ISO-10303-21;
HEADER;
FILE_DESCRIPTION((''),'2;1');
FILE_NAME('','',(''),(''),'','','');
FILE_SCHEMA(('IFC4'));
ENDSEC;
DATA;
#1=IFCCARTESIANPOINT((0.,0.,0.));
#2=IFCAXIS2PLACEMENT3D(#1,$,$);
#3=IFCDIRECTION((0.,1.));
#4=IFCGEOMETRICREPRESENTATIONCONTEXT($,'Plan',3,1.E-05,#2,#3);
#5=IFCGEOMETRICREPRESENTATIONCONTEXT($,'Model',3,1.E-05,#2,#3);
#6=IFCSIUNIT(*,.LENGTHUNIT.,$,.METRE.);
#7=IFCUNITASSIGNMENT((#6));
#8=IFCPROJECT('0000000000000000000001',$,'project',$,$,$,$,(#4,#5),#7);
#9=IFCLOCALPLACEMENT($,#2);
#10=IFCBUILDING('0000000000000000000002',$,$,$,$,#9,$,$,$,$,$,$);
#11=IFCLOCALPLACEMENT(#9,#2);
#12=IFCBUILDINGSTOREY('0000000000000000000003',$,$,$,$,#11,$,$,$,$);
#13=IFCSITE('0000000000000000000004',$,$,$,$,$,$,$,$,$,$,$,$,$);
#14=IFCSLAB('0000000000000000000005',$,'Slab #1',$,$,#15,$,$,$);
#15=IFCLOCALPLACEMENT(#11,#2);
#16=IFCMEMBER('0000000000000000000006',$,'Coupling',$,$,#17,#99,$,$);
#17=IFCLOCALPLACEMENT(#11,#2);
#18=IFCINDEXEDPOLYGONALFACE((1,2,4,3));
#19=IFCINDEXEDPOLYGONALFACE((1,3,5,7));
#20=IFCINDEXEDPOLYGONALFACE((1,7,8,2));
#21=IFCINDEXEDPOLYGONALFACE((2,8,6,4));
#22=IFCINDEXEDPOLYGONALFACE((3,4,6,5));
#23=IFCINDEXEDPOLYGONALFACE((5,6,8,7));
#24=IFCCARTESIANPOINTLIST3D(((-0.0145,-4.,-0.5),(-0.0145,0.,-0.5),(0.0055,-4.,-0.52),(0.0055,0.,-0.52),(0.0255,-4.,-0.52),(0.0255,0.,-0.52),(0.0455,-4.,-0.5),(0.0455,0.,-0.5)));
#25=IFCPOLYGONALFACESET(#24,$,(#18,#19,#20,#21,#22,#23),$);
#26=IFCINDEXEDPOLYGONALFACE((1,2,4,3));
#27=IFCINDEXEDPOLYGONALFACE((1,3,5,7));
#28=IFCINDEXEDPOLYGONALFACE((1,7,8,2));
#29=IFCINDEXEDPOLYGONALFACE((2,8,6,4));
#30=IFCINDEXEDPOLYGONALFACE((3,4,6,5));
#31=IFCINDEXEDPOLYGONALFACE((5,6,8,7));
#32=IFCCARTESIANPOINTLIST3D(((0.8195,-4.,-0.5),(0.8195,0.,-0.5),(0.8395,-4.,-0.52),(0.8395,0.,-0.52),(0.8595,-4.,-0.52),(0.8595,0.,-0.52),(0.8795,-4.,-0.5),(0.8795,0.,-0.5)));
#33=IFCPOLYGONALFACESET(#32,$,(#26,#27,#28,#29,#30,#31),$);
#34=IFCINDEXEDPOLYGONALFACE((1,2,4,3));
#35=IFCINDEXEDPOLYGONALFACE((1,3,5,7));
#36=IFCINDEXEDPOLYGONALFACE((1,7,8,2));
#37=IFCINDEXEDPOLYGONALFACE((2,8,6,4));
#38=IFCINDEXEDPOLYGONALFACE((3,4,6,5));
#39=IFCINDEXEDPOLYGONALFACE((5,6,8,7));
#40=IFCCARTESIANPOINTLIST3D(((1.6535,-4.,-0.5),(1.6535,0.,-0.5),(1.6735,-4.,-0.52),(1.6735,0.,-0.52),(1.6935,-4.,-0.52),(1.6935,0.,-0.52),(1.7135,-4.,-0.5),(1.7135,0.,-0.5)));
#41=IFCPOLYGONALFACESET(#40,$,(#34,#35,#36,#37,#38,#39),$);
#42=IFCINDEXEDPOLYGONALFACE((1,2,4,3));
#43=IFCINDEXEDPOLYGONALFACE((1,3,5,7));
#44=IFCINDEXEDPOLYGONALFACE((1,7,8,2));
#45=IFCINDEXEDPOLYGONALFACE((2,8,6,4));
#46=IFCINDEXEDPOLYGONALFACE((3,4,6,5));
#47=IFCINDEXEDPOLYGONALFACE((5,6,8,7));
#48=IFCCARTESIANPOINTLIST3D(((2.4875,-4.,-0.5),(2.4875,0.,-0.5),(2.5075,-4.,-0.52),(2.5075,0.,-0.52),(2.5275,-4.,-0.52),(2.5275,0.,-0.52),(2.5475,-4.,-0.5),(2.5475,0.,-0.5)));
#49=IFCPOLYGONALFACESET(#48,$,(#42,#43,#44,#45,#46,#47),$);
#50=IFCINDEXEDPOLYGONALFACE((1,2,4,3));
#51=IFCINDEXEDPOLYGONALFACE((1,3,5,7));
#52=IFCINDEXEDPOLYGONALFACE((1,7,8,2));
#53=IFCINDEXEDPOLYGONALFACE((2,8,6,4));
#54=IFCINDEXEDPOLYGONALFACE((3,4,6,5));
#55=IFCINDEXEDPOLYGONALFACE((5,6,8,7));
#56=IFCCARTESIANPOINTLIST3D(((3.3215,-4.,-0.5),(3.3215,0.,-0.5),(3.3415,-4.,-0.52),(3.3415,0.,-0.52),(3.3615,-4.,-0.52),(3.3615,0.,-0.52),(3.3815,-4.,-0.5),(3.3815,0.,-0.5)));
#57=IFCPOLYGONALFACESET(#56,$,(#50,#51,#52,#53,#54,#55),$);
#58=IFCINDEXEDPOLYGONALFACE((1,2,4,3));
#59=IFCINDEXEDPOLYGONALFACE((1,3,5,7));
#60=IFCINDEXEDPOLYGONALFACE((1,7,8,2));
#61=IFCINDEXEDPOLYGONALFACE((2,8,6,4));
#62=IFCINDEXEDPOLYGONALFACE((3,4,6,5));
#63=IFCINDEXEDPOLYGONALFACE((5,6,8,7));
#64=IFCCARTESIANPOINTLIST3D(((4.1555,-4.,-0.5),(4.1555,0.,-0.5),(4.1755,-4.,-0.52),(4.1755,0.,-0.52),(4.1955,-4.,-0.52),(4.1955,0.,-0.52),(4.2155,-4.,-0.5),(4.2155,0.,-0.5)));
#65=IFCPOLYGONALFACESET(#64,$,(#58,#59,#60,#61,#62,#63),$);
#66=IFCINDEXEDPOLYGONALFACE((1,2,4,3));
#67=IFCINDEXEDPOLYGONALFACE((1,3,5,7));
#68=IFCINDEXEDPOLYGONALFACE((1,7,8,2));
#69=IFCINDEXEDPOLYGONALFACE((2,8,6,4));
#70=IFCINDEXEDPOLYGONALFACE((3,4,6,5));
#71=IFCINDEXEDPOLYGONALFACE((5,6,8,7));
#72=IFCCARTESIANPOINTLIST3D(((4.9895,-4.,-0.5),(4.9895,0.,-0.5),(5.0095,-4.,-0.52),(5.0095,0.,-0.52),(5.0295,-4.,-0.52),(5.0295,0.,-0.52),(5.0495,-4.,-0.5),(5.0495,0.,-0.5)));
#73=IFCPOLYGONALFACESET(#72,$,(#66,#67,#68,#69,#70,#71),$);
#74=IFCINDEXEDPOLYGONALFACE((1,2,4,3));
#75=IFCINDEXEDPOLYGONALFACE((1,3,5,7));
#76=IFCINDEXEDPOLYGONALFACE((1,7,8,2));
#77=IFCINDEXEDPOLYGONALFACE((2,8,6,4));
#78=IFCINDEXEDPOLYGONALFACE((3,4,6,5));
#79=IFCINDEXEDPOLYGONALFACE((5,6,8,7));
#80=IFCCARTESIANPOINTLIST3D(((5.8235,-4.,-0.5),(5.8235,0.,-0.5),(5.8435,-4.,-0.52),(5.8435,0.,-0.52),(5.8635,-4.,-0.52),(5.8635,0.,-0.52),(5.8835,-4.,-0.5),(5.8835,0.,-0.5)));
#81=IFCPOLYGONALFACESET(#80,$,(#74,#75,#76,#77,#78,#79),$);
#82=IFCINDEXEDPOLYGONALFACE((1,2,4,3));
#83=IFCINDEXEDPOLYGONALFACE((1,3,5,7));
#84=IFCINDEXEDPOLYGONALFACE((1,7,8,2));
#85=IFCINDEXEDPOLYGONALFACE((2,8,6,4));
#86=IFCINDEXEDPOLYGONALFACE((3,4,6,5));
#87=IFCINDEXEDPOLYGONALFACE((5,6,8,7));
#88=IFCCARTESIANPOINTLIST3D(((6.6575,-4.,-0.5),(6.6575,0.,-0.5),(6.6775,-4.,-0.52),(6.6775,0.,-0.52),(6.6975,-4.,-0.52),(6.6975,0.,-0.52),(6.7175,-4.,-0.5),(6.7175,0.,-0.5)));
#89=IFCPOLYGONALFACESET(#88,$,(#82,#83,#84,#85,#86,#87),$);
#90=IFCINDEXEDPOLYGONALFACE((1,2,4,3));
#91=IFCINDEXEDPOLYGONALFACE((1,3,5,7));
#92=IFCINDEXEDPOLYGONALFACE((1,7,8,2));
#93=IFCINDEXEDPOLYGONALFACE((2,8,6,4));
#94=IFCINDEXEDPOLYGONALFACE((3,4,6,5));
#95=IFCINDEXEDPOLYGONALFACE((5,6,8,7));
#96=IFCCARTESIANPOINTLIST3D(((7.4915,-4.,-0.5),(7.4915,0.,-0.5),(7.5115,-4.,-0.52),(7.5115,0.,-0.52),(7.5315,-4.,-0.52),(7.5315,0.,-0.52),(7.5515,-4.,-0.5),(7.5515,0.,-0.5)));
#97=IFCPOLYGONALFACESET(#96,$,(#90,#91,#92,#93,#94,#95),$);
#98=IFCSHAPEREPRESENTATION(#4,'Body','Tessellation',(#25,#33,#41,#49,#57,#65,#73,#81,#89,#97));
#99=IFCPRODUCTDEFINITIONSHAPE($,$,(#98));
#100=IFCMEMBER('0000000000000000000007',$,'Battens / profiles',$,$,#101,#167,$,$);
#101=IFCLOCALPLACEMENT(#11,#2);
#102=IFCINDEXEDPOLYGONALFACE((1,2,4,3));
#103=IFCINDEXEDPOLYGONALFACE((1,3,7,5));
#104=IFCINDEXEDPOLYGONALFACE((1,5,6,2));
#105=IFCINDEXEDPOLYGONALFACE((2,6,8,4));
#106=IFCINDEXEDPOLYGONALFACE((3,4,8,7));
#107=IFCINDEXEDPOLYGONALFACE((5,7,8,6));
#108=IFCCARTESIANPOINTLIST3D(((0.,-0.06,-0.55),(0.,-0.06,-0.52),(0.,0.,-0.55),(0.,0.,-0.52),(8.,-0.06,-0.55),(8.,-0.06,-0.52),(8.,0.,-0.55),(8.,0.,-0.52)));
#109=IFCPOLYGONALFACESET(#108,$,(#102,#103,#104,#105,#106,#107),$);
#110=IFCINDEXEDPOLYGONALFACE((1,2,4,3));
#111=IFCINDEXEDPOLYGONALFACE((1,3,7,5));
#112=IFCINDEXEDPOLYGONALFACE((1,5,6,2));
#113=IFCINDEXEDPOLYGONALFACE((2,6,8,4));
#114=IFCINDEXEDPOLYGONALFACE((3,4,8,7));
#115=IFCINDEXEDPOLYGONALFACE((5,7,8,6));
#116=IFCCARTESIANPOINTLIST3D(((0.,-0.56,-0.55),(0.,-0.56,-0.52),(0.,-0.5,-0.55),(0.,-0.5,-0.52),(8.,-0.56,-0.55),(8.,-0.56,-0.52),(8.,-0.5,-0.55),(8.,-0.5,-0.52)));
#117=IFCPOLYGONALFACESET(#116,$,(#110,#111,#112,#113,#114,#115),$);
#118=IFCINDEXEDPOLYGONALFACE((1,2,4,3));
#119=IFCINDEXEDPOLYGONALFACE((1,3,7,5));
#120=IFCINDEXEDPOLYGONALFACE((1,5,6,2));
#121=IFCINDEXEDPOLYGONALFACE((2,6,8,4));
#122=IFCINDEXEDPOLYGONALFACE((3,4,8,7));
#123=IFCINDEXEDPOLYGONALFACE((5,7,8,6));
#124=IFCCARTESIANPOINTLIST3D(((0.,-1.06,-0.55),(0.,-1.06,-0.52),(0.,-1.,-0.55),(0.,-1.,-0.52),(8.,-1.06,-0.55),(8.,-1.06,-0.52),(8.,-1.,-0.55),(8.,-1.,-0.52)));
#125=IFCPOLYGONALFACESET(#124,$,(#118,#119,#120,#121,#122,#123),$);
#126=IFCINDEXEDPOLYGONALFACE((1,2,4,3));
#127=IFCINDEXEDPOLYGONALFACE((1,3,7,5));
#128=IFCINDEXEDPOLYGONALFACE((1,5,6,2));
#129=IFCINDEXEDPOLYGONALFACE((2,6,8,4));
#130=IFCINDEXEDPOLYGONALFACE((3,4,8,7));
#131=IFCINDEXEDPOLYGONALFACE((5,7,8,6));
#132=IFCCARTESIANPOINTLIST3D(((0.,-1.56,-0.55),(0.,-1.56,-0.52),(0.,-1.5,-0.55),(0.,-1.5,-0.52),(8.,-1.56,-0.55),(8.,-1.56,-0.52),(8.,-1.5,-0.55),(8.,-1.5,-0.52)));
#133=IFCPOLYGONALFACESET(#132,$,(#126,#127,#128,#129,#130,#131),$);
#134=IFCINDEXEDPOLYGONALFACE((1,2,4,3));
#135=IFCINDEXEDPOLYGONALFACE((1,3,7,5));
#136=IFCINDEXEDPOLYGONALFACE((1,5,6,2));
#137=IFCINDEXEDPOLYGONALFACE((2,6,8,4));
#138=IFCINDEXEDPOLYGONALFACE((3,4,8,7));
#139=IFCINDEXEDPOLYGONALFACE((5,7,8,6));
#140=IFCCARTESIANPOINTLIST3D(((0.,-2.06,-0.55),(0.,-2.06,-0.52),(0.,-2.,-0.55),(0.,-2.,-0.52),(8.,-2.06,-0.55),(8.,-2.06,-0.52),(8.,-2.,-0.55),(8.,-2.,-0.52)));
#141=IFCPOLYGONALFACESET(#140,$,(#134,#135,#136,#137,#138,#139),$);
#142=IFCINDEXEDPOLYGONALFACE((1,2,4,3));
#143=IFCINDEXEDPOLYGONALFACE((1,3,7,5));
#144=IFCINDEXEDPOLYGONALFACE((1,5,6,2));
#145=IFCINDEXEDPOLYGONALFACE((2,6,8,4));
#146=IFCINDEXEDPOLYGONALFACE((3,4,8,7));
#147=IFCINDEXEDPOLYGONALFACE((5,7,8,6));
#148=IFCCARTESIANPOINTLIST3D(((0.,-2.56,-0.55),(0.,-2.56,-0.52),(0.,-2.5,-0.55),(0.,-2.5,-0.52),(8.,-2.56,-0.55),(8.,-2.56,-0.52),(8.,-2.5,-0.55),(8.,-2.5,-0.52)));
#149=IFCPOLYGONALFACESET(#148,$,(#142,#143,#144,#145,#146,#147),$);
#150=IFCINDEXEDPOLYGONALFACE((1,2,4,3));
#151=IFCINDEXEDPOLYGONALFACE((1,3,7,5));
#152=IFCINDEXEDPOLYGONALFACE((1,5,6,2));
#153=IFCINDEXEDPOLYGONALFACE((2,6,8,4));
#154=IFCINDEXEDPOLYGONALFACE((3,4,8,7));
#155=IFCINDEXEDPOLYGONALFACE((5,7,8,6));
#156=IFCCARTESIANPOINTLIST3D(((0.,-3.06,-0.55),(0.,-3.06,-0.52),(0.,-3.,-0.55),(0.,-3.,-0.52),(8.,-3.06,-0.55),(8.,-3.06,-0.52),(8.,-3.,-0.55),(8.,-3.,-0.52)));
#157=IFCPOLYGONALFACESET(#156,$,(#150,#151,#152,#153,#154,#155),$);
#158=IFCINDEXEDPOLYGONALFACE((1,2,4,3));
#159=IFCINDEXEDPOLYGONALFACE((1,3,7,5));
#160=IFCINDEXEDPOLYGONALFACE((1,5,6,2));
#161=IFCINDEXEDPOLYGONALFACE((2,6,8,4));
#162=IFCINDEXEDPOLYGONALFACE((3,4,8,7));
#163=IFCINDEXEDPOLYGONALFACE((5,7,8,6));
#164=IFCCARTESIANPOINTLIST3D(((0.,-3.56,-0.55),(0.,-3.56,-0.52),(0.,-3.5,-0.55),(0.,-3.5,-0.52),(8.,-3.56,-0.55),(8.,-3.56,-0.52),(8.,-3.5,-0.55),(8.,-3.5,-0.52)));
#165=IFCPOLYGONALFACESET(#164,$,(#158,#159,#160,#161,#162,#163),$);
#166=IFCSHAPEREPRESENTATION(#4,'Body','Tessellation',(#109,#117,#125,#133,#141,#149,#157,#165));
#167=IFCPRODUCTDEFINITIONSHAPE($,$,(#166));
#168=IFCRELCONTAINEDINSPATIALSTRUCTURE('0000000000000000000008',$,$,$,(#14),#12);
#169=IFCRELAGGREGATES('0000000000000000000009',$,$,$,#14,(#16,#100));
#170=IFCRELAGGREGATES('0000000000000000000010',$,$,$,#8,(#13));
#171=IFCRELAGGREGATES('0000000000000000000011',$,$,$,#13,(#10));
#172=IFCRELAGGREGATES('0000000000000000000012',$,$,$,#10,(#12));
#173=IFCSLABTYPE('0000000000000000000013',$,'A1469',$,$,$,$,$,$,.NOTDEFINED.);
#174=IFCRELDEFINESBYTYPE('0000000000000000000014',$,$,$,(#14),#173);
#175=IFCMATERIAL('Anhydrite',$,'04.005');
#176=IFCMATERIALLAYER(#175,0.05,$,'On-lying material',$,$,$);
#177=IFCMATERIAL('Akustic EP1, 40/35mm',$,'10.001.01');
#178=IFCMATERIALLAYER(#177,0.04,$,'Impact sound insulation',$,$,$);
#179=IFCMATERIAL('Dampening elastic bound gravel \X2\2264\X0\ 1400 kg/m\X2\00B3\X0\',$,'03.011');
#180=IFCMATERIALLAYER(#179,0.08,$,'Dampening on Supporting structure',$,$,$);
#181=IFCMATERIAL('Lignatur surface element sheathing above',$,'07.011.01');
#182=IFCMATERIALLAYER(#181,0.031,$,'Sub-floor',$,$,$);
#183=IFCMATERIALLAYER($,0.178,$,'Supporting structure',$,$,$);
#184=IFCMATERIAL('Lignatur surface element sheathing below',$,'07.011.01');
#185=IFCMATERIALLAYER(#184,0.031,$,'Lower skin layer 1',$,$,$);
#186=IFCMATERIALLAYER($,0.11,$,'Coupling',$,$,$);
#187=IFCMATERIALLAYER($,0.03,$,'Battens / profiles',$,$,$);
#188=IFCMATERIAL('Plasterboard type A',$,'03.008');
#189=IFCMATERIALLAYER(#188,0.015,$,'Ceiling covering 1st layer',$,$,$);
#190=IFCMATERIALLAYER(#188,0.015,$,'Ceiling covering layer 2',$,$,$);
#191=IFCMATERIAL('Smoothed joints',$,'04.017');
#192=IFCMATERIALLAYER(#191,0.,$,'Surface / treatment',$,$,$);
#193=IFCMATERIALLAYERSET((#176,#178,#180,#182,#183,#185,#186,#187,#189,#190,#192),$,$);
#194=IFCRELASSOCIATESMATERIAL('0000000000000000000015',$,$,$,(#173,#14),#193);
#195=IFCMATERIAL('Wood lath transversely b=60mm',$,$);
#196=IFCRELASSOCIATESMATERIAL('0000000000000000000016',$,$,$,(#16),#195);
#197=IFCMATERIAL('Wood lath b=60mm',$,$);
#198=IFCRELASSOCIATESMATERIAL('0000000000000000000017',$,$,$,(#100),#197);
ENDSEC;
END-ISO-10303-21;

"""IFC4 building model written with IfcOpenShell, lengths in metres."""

from ifc_helpers import new_model, si_unit, direction, frame, frame_2d, origin, place, context, project, spatial, polyline, rectangle, outline, extrude, material, layer, layer_set, type_object, element, aggregate, save


model = new_model("IFC4")

# Units and contexts
plan_context = context("Plan", 3, precision=1e-05, world=origin(), true_north=direction((0.0, 1.0)))
model_context = context("Model", 3, precision=1e-05, world=origin(), true_north=direction((0.0, 1.0)))
ifc_project = project(units=[si_unit("LENGTHUNIT", "METRE")], contexts=[plan_context, model_context])

# Site, building, storey
site = spatial("IfcSite", under=ifc_project)
building_placement = place(None, origin())
building = spatial("IfcBuilding", under=site, at=building_placement)
storey_placement = place(building_placement, origin())
storey = spatial("IfcBuildingStorey", under=building, at=storey_placement)

# Slab, members
ifc_material_1 = material(Name="Anhydrite", Category="04.005")
ifc_layer_1 = layer(ifc_material_1, 0.05, Name="On-lying material")
ifc_material_2 = material(Name="Akustic EP1, 40/35mm", Category="10.001.01")
ifc_layer_2 = layer(ifc_material_2, 0.04, Name="Impact sound insulation")
ifc_material_3 = material(Name="Dampening elastic bound gravel ≤ 1400 kg/m³", Category="03.011")
ifc_layer_3 = layer(ifc_material_3, 0.08, Name="Dampening on Supporting structure")
ifc_material_4 = material(Name="Lignatur surface element sheathing above", Category="07.011.01")
ifc_layer_4 = layer(ifc_material_4, 0.031, Name="Sub-floor")
ifc_layer_5 = layer(None, 0.178, Name="Supporting structure")
ifc_material_5 = material(Name="Lignatur surface element sheathing below", Category="07.011.01")
ifc_layer_6 = layer(ifc_material_5, 0.031, Name="Lower skin layer 1")
ifc_layer_7 = layer(None, 0.11, Name="Coupling")
ifc_layer_8 = layer(None, 0.03, Name="Battens / profiles")
ifc_material_6 = material(Name="Plasterboard type A", Category="03.008")
ifc_layer_9 = layer(ifc_material_6, 0.015, Name="Ceiling covering 1st layer")
ifc_layer_10 = layer(ifc_material_6, 0.015, Name="Ceiling covering layer 2")
ifc_material_7 = material(Name="Smoothed joints", Category="04.017")
ifc_layer_11 = layer(ifc_material_7, 0.0, Name="Surface / treatment")
ifc_layer_set = layer_set([ifc_layer_1, ifc_layer_2, ifc_layer_3, ifc_layer_4, ifc_layer_5, ifc_layer_6, ifc_layer_7, ifc_layer_8, ifc_layer_9, ifc_layer_10, ifc_layer_11])
slab_type = type_object("IfcSlabType", Name="A1469", PredefinedType="NOTDEFINED", material=ifc_layer_set)
slab_placement = place(None, frame((0.0, 0.0, 0.0), z_axis=(0.0, 0.0, -1.0), x_axis=(1.0, 0.0, 0.0)))
slab = element("IfcSlab", 1, at=slab_placement, inside=storey, type_object=slab_type, material=ifc_layer_set, Name="Slab #1")
ifc_material_8 = material(Name="Wood lath transversely b=60mm")
member_1_placement = place(slab_placement, origin())
member_1 = element("IfcMember", 2, at=member_1_placement, material=ifc_material_8, Name="Coupling", context=plan_context, shape_type="SweptSolid", body=[
    extrude(outline(polyline([(0.0, 0.0), (0.06, 0.0), (0.04, 0.02), (0.02, 0.02), (0.0, 0.0)])), frame((-0.0145, 4.0, 0.5), z_axis=(0.0, -1.0, 0.0), x_axis=(1.0, 0.0, 0.0)), (0.0, 0.0, 1.0), 4.0),
    extrude(outline(polyline([(0.0, 0.0), (0.06, 0.0), (0.04, 0.02), (0.02, 0.02), (0.0, 0.0)])), frame((0.8195, 4.0, 0.5), z_axis=(0.0, -1.0, 0.0), x_axis=(1.0, 0.0, 0.0)), (0.0, 0.0, 1.0), 4.0),
    extrude(outline(polyline([(0.0, 0.0), (0.06, 0.0), (0.04, 0.02), (0.02, 0.02), (0.0, 0.0)])), frame((1.6535, 4.0, 0.5), z_axis=(0.0, -1.0, 0.0), x_axis=(1.0, 0.0, 0.0)), (0.0, 0.0, 1.0), 4.0),
    extrude(outline(polyline([(0.0, 0.0), (0.06, 0.0), (0.04, 0.02), (0.02, 0.02), (0.0, 0.0)])), frame((2.4875, 4.0, 0.5), z_axis=(0.0, -1.0, 0.0), x_axis=(1.0, 0.0, 0.0)), (0.0, 0.0, 1.0), 4.0),
    extrude(outline(polyline([(0.0, 0.0), (0.06, 0.0), (0.04, 0.02), (0.02, 0.02), (0.0, 0.0)])), frame((3.3215, 4.0, 0.5), z_axis=(0.0, -1.0, 0.0), x_axis=(1.0, 0.0, 0.0)), (0.0, 0.0, 1.0), 4.0),
    extrude(outline(polyline([(0.0, 0.0), (0.06, 0.0), (0.04, 0.02), (0.02, 0.02), (0.0, 0.0)])), frame((4.1555, 4.0, 0.5), z_axis=(0.0, -1.0, 0.0), x_axis=(1.0, 0.0, 0.0)), (0.0, 0.0, 1.0), 4.0),
    extrude(outline(polyline([(0.0, 0.0), (0.06, 0.0), (0.04, 0.02), (0.02, 0.02), (0.0, 0.0)])), frame((4.9895, 4.0, 0.5), z_axis=(0.0, -1.0, 0.0), x_axis=(1.0, 0.0, 0.0)), (0.0, 0.0, 1.0), 4.0),
    extrude(outline(polyline([(0.0, 0.0), (0.06, 0.0), (0.04, 0.02), (0.02, 0.02), (0.0, 0.0)])), frame((5.8235, 4.0, 0.5), z_axis=(0.0, -1.0, 0.0), x_axis=(1.0, 0.0, 0.0)), (0.0, 0.0, 1.0), 4.0),
    extrude(outline(polyline([(0.0, 0.0), (0.06, 0.0), (0.04, 0.02), (0.02, 0.02), (0.0, 0.0)])), frame((6.6575, 4.0, 0.5), z_axis=(0.0, -1.0, 0.0), x_axis=(1.0, 0.0, 0.0)), (0.0, 0.0, 1.0), 4.0),
    extrude(outline(polyline([(0.0, 0.0), (0.06, 0.0), (0.04, 0.02), (0.02, 0.02), (0.0, 0.0)])), frame((7.4915, 4.0, 0.5), z_axis=(0.0, -1.0, 0.0), x_axis=(1.0, 0.0, 0.0)), (0.0, 0.0, 1.0), 4.0),
])
ifc_material_9 = material(Name="Wood lath b=60mm")
member_2_placement = place(slab_placement, origin())
member_2 = element("IfcMember", 3, at=member_2_placement, material=ifc_material_9, Name="Battens / profiles", context=plan_context, shape_type="SweptSolid", body=[
    extrude(rectangle(XDim=0.06, YDim=0.03, at=frame_2d((0.03, 0.015), x_axis=(1.0, 0.0))), frame((0.0, 0.0, 0.52), z_axis=(1.0, 0.0, 0.0), x_axis=(0.0, 1.0, 0.0)), (0.0, 0.0, 1.0), 8.0),
    extrude(rectangle(XDim=0.06, YDim=0.03, at=frame_2d((0.03, 0.015), x_axis=(1.0, 0.0))), frame((0.0, 0.5, 0.52), z_axis=(1.0, 0.0, 0.0), x_axis=(0.0, 1.0, 0.0)), (0.0, 0.0, 1.0), 8.0),
    extrude(rectangle(XDim=0.06, YDim=0.03, at=frame_2d((0.03, 0.015), x_axis=(1.0, 0.0))), frame((0.0, 1.0, 0.52), z_axis=(1.0, 0.0, 0.0), x_axis=(0.0, 1.0, 0.0)), (0.0, 0.0, 1.0), 8.0),
    extrude(rectangle(XDim=0.06, YDim=0.03, at=frame_2d((0.03, 0.015), x_axis=(1.0, 0.0))), frame((0.0, 1.5, 0.52), z_axis=(1.0, 0.0, 0.0), x_axis=(0.0, 1.0, 0.0)), (0.0, 0.0, 1.0), 8.0),
    extrude(rectangle(XDim=0.06, YDim=0.03, at=frame_2d((0.03, 0.015), x_axis=(1.0, 0.0))), frame((0.0, 2.0, 0.52), z_axis=(1.0, 0.0, 0.0), x_axis=(0.0, 1.0, 0.0)), (0.0, 0.0, 1.0), 8.0),
    extrude(rectangle(XDim=0.06, YDim=0.03, at=frame_2d((0.03, 0.015), x_axis=(1.0, 0.0))), frame((0.0, 2.5, 0.52), z_axis=(1.0, 0.0, 0.0), x_axis=(0.0, 1.0, 0.0)), (0.0, 0.0, 1.0), 8.0),
    extrude(rectangle(XDim=0.06, YDim=0.03, at=frame_2d((0.03, 0.015), x_axis=(1.0, 0.0))), frame((0.0, 3.0, 0.52), z_axis=(1.0, 0.0, 0.0), x_axis=(0.0, 1.0, 0.0)), (0.0, 0.0, 1.0), 8.0),
    extrude(rectangle(XDim=0.06, YDim=0.03, at=frame_2d((0.03, 0.015), x_axis=(1.0, 0.0))), frame((0.0, 3.5, 0.52), z_axis=(1.0, 0.0, 0.0), x_axis=(0.0, 1.0, 0.0)), (0.0, 0.0, 1.0), 8.0),
])
aggregate(slab, [member_1, member_2])

save(model, "model.ifc")
